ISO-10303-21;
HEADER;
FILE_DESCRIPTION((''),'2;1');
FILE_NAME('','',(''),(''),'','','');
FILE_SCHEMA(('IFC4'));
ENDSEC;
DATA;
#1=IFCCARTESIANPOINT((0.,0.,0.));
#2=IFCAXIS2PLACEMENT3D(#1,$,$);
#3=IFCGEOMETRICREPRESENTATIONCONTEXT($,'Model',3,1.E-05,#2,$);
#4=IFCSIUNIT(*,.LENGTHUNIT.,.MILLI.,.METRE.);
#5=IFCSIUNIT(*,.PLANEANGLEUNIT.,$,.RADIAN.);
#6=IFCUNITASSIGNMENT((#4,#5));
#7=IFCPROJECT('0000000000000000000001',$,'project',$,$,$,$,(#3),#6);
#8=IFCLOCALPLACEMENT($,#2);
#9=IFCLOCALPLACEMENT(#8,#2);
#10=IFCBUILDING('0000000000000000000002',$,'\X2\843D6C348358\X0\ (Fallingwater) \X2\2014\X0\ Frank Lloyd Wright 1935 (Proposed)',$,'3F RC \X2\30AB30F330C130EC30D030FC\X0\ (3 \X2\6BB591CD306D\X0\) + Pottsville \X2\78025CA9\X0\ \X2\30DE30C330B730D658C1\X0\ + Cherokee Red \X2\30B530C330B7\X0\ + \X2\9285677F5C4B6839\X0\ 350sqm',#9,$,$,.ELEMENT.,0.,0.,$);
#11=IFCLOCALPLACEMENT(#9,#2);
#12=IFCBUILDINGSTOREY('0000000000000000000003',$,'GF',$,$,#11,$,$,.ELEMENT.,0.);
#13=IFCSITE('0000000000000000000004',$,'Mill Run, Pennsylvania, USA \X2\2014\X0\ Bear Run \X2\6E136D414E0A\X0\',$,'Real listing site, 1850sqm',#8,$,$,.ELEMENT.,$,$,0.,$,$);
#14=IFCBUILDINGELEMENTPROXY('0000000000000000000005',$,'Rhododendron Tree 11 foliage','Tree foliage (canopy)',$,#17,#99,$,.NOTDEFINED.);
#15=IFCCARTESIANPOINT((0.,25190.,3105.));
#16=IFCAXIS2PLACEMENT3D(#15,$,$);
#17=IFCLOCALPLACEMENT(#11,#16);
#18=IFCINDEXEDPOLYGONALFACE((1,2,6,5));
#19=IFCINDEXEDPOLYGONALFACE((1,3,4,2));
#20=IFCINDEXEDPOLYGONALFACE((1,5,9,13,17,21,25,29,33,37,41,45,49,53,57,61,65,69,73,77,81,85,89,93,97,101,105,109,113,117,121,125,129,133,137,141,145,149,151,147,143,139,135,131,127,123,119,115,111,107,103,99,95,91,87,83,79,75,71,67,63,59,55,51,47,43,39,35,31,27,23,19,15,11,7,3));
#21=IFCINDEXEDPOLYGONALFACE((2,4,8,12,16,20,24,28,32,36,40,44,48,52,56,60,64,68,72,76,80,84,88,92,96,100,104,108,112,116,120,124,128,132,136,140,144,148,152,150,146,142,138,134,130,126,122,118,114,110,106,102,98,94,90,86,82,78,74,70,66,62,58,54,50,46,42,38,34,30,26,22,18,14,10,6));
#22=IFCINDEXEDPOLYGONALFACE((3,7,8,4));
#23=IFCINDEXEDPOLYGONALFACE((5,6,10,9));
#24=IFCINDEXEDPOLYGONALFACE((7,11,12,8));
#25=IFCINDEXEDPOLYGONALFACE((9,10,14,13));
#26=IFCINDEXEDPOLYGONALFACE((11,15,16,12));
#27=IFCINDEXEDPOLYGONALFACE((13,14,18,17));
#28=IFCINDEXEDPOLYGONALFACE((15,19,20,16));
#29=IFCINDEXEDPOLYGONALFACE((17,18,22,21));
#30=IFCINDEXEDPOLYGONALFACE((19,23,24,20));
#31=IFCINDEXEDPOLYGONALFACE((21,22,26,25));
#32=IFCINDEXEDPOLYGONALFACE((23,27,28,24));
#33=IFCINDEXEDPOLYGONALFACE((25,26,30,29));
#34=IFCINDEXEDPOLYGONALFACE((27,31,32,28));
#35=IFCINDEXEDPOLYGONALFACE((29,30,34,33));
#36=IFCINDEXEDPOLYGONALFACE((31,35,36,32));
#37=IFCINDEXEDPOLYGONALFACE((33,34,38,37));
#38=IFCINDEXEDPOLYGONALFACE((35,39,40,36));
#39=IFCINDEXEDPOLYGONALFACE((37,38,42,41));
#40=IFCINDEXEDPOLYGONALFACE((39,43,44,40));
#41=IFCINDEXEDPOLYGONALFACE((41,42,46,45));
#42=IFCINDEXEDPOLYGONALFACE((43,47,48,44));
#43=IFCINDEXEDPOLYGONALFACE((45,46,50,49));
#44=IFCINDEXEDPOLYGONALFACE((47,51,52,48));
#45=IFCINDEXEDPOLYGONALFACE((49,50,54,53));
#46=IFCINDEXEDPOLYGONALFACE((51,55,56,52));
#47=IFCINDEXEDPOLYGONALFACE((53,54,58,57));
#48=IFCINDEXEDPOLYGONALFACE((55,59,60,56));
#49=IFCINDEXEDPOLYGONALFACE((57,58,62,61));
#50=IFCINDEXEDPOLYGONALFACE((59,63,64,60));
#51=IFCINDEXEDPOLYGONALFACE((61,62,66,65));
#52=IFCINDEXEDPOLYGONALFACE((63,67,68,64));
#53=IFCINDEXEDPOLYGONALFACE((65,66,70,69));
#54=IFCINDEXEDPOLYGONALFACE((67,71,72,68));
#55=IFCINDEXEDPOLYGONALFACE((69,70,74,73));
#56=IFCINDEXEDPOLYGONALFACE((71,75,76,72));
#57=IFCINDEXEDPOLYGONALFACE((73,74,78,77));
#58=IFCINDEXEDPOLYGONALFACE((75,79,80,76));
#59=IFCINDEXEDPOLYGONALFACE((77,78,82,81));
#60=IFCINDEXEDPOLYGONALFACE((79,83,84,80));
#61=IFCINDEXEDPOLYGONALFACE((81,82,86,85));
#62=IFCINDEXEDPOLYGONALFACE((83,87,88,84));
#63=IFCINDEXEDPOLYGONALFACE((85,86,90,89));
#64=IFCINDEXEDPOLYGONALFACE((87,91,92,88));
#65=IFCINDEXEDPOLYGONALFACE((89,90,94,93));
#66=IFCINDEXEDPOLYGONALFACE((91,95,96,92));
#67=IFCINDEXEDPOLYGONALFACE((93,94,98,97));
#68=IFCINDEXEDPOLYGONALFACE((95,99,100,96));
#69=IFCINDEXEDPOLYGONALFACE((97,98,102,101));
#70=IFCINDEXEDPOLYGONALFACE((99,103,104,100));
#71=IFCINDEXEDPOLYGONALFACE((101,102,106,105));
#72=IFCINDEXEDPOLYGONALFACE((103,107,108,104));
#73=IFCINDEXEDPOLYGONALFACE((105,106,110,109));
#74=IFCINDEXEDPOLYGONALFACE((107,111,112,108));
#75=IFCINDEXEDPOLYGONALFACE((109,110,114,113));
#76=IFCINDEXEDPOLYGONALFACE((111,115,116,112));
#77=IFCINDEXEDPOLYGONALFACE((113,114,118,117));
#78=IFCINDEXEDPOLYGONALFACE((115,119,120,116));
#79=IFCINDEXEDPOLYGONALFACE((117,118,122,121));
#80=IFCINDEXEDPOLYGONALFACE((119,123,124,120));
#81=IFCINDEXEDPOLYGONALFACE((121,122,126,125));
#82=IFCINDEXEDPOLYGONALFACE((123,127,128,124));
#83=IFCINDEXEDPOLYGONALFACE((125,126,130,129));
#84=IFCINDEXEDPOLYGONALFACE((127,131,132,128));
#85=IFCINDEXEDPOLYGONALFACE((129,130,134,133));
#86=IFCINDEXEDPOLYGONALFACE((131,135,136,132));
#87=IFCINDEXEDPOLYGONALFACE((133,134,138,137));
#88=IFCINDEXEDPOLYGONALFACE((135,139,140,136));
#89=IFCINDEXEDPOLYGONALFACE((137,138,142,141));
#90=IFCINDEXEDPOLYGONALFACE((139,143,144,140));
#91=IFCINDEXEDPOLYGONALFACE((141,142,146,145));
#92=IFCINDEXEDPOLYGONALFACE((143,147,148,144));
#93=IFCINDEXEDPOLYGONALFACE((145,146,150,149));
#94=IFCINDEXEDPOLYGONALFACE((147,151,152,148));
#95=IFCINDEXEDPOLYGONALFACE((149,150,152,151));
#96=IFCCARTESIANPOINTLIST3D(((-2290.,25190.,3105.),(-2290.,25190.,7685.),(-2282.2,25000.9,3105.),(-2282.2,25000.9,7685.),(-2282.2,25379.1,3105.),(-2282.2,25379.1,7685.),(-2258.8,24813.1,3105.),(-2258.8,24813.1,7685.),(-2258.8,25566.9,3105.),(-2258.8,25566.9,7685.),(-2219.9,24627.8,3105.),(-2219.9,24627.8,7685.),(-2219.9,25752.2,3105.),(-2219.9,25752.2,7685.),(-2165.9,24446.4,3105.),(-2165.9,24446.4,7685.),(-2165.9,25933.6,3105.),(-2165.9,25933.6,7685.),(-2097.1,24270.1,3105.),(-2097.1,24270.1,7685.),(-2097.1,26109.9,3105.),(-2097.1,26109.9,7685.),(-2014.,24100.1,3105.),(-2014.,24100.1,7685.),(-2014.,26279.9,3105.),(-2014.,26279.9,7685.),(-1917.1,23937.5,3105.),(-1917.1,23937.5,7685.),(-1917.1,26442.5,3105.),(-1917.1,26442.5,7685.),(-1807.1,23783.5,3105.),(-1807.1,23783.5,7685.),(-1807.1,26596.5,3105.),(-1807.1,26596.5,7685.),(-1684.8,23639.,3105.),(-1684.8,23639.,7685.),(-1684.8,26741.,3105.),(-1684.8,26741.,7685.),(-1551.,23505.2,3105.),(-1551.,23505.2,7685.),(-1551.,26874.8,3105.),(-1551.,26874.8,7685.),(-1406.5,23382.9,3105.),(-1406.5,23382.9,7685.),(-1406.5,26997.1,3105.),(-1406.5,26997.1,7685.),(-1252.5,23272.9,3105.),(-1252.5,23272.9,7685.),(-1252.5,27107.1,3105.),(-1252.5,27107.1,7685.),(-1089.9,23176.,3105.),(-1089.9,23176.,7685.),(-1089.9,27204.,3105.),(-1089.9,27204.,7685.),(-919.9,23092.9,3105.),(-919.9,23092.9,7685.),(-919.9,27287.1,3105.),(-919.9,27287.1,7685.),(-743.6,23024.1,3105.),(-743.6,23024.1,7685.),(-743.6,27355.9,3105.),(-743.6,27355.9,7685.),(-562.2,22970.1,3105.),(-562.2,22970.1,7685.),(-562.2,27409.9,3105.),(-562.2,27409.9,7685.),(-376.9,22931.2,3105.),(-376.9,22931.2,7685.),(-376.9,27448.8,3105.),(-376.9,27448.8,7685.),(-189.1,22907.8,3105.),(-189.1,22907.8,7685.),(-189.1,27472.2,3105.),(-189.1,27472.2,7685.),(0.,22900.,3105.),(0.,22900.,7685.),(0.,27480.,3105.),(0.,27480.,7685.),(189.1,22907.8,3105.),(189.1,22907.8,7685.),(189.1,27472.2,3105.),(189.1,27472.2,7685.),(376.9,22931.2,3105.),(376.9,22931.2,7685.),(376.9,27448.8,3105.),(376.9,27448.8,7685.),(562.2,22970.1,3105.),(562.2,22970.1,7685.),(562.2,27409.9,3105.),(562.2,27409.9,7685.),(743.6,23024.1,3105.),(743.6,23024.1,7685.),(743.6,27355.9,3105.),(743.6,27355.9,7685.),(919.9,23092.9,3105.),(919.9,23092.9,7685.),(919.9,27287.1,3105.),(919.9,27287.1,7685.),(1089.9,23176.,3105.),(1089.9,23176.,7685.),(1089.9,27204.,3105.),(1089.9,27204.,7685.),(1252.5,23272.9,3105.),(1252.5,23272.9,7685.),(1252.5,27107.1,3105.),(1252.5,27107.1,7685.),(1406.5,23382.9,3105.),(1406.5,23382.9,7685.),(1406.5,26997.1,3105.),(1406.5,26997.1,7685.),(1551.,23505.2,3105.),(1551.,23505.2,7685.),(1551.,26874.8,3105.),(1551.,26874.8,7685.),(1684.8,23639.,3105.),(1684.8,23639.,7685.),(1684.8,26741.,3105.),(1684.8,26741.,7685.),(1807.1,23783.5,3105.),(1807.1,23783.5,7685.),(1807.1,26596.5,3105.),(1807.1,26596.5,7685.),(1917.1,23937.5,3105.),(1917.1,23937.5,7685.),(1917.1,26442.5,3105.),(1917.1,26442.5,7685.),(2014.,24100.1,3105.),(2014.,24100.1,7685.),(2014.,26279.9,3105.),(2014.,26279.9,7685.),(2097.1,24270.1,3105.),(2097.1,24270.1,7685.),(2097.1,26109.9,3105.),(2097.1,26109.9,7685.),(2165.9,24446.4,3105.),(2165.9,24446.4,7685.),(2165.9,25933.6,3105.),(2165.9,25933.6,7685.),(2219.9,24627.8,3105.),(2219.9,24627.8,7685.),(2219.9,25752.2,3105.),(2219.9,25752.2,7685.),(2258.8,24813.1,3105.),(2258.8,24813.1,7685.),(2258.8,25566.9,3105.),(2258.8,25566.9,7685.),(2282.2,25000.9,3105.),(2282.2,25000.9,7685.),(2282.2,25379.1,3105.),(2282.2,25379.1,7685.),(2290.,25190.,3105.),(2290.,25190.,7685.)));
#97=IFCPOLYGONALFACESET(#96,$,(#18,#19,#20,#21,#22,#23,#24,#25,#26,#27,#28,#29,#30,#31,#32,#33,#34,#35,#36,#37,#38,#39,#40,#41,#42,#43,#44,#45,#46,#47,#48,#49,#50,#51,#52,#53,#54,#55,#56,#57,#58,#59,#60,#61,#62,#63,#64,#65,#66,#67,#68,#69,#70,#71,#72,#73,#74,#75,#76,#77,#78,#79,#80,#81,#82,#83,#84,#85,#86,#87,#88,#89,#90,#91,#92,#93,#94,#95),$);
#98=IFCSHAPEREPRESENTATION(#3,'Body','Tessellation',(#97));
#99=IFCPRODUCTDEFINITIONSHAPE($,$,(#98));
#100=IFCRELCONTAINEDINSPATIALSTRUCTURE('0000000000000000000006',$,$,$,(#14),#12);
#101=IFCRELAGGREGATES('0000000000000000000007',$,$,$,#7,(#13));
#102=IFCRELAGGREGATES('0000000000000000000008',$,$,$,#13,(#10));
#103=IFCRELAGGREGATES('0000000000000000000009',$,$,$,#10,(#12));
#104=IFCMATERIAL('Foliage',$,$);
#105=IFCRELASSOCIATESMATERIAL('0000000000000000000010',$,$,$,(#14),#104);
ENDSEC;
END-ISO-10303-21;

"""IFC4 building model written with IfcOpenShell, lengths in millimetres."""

from ifc_helpers import new_model, si_unit, frame, origin, origin_2d, place, context, project, spatial, circle, extrude, material, element, save


model = new_model("IFC4")

# Units and contexts
model_context = context("Model", 3, precision=1e-05, world=origin())
ifc_project = project(units=[si_unit("LENGTHUNIT", "METRE", prefix="MILLI"), si_unit("PLANEANGLEUNIT", "RADIAN")], contexts=[model_context])

# Site, building, storey
site_placement = place(None, origin())
site = spatial("IfcSite", under=ifc_project, at=site_placement, Name="Mill Run, Pennsylvania, USA — Bear Run 渓流上", ObjectType="Real listing site, 1850sqm", CompositionType="ELEMENT", RefElevation=0.0)
building_placement = place(site_placement, origin())
building = spatial("IfcBuilding", under=site, at=building_placement, Name="落水荘 (Fallingwater) — Frank Lloyd Wright 1935 (Proposed)", ObjectType="3F RC カンチレバー (3 段重ね) + Pottsville 砂岩 マッシブ壁 + Cherokee Red サッシ + 銅板屋根 350sqm", CompositionType="ELEMENT", ElevationOfRefHeight=0.0, ElevationOfTerrain=0.0)
storey_placement = place(building_placement, origin())
storey = spatial("IfcBuildingStorey", under=building, at=storey_placement, Name="GF", CompositionType="ELEMENT", Elevation=0.0)

# Building element proxy
ifc_material_1 = material(Name="Foliage")
proxy_1_placement = place(storey_placement, frame((0.0, 25190.0, 3105.0)))
element("IfcBuildingElementProxy", 1, at=proxy_1_placement, inside=storey, material=ifc_material_1, Name="Rhododendron Tree 11 foliage", Description="Tree foliage (canopy)", PredefinedType="NOTDEFINED", context=model_context, shape_type="SweptSolid", body=[
    extrude(circle(Radius=2290.0, at=origin_2d()), frame((0.0, 25190.0, 3105.0)), (0.0, 0.0, 1.0), 4580.0),
])

save(model, "model.ifc")
